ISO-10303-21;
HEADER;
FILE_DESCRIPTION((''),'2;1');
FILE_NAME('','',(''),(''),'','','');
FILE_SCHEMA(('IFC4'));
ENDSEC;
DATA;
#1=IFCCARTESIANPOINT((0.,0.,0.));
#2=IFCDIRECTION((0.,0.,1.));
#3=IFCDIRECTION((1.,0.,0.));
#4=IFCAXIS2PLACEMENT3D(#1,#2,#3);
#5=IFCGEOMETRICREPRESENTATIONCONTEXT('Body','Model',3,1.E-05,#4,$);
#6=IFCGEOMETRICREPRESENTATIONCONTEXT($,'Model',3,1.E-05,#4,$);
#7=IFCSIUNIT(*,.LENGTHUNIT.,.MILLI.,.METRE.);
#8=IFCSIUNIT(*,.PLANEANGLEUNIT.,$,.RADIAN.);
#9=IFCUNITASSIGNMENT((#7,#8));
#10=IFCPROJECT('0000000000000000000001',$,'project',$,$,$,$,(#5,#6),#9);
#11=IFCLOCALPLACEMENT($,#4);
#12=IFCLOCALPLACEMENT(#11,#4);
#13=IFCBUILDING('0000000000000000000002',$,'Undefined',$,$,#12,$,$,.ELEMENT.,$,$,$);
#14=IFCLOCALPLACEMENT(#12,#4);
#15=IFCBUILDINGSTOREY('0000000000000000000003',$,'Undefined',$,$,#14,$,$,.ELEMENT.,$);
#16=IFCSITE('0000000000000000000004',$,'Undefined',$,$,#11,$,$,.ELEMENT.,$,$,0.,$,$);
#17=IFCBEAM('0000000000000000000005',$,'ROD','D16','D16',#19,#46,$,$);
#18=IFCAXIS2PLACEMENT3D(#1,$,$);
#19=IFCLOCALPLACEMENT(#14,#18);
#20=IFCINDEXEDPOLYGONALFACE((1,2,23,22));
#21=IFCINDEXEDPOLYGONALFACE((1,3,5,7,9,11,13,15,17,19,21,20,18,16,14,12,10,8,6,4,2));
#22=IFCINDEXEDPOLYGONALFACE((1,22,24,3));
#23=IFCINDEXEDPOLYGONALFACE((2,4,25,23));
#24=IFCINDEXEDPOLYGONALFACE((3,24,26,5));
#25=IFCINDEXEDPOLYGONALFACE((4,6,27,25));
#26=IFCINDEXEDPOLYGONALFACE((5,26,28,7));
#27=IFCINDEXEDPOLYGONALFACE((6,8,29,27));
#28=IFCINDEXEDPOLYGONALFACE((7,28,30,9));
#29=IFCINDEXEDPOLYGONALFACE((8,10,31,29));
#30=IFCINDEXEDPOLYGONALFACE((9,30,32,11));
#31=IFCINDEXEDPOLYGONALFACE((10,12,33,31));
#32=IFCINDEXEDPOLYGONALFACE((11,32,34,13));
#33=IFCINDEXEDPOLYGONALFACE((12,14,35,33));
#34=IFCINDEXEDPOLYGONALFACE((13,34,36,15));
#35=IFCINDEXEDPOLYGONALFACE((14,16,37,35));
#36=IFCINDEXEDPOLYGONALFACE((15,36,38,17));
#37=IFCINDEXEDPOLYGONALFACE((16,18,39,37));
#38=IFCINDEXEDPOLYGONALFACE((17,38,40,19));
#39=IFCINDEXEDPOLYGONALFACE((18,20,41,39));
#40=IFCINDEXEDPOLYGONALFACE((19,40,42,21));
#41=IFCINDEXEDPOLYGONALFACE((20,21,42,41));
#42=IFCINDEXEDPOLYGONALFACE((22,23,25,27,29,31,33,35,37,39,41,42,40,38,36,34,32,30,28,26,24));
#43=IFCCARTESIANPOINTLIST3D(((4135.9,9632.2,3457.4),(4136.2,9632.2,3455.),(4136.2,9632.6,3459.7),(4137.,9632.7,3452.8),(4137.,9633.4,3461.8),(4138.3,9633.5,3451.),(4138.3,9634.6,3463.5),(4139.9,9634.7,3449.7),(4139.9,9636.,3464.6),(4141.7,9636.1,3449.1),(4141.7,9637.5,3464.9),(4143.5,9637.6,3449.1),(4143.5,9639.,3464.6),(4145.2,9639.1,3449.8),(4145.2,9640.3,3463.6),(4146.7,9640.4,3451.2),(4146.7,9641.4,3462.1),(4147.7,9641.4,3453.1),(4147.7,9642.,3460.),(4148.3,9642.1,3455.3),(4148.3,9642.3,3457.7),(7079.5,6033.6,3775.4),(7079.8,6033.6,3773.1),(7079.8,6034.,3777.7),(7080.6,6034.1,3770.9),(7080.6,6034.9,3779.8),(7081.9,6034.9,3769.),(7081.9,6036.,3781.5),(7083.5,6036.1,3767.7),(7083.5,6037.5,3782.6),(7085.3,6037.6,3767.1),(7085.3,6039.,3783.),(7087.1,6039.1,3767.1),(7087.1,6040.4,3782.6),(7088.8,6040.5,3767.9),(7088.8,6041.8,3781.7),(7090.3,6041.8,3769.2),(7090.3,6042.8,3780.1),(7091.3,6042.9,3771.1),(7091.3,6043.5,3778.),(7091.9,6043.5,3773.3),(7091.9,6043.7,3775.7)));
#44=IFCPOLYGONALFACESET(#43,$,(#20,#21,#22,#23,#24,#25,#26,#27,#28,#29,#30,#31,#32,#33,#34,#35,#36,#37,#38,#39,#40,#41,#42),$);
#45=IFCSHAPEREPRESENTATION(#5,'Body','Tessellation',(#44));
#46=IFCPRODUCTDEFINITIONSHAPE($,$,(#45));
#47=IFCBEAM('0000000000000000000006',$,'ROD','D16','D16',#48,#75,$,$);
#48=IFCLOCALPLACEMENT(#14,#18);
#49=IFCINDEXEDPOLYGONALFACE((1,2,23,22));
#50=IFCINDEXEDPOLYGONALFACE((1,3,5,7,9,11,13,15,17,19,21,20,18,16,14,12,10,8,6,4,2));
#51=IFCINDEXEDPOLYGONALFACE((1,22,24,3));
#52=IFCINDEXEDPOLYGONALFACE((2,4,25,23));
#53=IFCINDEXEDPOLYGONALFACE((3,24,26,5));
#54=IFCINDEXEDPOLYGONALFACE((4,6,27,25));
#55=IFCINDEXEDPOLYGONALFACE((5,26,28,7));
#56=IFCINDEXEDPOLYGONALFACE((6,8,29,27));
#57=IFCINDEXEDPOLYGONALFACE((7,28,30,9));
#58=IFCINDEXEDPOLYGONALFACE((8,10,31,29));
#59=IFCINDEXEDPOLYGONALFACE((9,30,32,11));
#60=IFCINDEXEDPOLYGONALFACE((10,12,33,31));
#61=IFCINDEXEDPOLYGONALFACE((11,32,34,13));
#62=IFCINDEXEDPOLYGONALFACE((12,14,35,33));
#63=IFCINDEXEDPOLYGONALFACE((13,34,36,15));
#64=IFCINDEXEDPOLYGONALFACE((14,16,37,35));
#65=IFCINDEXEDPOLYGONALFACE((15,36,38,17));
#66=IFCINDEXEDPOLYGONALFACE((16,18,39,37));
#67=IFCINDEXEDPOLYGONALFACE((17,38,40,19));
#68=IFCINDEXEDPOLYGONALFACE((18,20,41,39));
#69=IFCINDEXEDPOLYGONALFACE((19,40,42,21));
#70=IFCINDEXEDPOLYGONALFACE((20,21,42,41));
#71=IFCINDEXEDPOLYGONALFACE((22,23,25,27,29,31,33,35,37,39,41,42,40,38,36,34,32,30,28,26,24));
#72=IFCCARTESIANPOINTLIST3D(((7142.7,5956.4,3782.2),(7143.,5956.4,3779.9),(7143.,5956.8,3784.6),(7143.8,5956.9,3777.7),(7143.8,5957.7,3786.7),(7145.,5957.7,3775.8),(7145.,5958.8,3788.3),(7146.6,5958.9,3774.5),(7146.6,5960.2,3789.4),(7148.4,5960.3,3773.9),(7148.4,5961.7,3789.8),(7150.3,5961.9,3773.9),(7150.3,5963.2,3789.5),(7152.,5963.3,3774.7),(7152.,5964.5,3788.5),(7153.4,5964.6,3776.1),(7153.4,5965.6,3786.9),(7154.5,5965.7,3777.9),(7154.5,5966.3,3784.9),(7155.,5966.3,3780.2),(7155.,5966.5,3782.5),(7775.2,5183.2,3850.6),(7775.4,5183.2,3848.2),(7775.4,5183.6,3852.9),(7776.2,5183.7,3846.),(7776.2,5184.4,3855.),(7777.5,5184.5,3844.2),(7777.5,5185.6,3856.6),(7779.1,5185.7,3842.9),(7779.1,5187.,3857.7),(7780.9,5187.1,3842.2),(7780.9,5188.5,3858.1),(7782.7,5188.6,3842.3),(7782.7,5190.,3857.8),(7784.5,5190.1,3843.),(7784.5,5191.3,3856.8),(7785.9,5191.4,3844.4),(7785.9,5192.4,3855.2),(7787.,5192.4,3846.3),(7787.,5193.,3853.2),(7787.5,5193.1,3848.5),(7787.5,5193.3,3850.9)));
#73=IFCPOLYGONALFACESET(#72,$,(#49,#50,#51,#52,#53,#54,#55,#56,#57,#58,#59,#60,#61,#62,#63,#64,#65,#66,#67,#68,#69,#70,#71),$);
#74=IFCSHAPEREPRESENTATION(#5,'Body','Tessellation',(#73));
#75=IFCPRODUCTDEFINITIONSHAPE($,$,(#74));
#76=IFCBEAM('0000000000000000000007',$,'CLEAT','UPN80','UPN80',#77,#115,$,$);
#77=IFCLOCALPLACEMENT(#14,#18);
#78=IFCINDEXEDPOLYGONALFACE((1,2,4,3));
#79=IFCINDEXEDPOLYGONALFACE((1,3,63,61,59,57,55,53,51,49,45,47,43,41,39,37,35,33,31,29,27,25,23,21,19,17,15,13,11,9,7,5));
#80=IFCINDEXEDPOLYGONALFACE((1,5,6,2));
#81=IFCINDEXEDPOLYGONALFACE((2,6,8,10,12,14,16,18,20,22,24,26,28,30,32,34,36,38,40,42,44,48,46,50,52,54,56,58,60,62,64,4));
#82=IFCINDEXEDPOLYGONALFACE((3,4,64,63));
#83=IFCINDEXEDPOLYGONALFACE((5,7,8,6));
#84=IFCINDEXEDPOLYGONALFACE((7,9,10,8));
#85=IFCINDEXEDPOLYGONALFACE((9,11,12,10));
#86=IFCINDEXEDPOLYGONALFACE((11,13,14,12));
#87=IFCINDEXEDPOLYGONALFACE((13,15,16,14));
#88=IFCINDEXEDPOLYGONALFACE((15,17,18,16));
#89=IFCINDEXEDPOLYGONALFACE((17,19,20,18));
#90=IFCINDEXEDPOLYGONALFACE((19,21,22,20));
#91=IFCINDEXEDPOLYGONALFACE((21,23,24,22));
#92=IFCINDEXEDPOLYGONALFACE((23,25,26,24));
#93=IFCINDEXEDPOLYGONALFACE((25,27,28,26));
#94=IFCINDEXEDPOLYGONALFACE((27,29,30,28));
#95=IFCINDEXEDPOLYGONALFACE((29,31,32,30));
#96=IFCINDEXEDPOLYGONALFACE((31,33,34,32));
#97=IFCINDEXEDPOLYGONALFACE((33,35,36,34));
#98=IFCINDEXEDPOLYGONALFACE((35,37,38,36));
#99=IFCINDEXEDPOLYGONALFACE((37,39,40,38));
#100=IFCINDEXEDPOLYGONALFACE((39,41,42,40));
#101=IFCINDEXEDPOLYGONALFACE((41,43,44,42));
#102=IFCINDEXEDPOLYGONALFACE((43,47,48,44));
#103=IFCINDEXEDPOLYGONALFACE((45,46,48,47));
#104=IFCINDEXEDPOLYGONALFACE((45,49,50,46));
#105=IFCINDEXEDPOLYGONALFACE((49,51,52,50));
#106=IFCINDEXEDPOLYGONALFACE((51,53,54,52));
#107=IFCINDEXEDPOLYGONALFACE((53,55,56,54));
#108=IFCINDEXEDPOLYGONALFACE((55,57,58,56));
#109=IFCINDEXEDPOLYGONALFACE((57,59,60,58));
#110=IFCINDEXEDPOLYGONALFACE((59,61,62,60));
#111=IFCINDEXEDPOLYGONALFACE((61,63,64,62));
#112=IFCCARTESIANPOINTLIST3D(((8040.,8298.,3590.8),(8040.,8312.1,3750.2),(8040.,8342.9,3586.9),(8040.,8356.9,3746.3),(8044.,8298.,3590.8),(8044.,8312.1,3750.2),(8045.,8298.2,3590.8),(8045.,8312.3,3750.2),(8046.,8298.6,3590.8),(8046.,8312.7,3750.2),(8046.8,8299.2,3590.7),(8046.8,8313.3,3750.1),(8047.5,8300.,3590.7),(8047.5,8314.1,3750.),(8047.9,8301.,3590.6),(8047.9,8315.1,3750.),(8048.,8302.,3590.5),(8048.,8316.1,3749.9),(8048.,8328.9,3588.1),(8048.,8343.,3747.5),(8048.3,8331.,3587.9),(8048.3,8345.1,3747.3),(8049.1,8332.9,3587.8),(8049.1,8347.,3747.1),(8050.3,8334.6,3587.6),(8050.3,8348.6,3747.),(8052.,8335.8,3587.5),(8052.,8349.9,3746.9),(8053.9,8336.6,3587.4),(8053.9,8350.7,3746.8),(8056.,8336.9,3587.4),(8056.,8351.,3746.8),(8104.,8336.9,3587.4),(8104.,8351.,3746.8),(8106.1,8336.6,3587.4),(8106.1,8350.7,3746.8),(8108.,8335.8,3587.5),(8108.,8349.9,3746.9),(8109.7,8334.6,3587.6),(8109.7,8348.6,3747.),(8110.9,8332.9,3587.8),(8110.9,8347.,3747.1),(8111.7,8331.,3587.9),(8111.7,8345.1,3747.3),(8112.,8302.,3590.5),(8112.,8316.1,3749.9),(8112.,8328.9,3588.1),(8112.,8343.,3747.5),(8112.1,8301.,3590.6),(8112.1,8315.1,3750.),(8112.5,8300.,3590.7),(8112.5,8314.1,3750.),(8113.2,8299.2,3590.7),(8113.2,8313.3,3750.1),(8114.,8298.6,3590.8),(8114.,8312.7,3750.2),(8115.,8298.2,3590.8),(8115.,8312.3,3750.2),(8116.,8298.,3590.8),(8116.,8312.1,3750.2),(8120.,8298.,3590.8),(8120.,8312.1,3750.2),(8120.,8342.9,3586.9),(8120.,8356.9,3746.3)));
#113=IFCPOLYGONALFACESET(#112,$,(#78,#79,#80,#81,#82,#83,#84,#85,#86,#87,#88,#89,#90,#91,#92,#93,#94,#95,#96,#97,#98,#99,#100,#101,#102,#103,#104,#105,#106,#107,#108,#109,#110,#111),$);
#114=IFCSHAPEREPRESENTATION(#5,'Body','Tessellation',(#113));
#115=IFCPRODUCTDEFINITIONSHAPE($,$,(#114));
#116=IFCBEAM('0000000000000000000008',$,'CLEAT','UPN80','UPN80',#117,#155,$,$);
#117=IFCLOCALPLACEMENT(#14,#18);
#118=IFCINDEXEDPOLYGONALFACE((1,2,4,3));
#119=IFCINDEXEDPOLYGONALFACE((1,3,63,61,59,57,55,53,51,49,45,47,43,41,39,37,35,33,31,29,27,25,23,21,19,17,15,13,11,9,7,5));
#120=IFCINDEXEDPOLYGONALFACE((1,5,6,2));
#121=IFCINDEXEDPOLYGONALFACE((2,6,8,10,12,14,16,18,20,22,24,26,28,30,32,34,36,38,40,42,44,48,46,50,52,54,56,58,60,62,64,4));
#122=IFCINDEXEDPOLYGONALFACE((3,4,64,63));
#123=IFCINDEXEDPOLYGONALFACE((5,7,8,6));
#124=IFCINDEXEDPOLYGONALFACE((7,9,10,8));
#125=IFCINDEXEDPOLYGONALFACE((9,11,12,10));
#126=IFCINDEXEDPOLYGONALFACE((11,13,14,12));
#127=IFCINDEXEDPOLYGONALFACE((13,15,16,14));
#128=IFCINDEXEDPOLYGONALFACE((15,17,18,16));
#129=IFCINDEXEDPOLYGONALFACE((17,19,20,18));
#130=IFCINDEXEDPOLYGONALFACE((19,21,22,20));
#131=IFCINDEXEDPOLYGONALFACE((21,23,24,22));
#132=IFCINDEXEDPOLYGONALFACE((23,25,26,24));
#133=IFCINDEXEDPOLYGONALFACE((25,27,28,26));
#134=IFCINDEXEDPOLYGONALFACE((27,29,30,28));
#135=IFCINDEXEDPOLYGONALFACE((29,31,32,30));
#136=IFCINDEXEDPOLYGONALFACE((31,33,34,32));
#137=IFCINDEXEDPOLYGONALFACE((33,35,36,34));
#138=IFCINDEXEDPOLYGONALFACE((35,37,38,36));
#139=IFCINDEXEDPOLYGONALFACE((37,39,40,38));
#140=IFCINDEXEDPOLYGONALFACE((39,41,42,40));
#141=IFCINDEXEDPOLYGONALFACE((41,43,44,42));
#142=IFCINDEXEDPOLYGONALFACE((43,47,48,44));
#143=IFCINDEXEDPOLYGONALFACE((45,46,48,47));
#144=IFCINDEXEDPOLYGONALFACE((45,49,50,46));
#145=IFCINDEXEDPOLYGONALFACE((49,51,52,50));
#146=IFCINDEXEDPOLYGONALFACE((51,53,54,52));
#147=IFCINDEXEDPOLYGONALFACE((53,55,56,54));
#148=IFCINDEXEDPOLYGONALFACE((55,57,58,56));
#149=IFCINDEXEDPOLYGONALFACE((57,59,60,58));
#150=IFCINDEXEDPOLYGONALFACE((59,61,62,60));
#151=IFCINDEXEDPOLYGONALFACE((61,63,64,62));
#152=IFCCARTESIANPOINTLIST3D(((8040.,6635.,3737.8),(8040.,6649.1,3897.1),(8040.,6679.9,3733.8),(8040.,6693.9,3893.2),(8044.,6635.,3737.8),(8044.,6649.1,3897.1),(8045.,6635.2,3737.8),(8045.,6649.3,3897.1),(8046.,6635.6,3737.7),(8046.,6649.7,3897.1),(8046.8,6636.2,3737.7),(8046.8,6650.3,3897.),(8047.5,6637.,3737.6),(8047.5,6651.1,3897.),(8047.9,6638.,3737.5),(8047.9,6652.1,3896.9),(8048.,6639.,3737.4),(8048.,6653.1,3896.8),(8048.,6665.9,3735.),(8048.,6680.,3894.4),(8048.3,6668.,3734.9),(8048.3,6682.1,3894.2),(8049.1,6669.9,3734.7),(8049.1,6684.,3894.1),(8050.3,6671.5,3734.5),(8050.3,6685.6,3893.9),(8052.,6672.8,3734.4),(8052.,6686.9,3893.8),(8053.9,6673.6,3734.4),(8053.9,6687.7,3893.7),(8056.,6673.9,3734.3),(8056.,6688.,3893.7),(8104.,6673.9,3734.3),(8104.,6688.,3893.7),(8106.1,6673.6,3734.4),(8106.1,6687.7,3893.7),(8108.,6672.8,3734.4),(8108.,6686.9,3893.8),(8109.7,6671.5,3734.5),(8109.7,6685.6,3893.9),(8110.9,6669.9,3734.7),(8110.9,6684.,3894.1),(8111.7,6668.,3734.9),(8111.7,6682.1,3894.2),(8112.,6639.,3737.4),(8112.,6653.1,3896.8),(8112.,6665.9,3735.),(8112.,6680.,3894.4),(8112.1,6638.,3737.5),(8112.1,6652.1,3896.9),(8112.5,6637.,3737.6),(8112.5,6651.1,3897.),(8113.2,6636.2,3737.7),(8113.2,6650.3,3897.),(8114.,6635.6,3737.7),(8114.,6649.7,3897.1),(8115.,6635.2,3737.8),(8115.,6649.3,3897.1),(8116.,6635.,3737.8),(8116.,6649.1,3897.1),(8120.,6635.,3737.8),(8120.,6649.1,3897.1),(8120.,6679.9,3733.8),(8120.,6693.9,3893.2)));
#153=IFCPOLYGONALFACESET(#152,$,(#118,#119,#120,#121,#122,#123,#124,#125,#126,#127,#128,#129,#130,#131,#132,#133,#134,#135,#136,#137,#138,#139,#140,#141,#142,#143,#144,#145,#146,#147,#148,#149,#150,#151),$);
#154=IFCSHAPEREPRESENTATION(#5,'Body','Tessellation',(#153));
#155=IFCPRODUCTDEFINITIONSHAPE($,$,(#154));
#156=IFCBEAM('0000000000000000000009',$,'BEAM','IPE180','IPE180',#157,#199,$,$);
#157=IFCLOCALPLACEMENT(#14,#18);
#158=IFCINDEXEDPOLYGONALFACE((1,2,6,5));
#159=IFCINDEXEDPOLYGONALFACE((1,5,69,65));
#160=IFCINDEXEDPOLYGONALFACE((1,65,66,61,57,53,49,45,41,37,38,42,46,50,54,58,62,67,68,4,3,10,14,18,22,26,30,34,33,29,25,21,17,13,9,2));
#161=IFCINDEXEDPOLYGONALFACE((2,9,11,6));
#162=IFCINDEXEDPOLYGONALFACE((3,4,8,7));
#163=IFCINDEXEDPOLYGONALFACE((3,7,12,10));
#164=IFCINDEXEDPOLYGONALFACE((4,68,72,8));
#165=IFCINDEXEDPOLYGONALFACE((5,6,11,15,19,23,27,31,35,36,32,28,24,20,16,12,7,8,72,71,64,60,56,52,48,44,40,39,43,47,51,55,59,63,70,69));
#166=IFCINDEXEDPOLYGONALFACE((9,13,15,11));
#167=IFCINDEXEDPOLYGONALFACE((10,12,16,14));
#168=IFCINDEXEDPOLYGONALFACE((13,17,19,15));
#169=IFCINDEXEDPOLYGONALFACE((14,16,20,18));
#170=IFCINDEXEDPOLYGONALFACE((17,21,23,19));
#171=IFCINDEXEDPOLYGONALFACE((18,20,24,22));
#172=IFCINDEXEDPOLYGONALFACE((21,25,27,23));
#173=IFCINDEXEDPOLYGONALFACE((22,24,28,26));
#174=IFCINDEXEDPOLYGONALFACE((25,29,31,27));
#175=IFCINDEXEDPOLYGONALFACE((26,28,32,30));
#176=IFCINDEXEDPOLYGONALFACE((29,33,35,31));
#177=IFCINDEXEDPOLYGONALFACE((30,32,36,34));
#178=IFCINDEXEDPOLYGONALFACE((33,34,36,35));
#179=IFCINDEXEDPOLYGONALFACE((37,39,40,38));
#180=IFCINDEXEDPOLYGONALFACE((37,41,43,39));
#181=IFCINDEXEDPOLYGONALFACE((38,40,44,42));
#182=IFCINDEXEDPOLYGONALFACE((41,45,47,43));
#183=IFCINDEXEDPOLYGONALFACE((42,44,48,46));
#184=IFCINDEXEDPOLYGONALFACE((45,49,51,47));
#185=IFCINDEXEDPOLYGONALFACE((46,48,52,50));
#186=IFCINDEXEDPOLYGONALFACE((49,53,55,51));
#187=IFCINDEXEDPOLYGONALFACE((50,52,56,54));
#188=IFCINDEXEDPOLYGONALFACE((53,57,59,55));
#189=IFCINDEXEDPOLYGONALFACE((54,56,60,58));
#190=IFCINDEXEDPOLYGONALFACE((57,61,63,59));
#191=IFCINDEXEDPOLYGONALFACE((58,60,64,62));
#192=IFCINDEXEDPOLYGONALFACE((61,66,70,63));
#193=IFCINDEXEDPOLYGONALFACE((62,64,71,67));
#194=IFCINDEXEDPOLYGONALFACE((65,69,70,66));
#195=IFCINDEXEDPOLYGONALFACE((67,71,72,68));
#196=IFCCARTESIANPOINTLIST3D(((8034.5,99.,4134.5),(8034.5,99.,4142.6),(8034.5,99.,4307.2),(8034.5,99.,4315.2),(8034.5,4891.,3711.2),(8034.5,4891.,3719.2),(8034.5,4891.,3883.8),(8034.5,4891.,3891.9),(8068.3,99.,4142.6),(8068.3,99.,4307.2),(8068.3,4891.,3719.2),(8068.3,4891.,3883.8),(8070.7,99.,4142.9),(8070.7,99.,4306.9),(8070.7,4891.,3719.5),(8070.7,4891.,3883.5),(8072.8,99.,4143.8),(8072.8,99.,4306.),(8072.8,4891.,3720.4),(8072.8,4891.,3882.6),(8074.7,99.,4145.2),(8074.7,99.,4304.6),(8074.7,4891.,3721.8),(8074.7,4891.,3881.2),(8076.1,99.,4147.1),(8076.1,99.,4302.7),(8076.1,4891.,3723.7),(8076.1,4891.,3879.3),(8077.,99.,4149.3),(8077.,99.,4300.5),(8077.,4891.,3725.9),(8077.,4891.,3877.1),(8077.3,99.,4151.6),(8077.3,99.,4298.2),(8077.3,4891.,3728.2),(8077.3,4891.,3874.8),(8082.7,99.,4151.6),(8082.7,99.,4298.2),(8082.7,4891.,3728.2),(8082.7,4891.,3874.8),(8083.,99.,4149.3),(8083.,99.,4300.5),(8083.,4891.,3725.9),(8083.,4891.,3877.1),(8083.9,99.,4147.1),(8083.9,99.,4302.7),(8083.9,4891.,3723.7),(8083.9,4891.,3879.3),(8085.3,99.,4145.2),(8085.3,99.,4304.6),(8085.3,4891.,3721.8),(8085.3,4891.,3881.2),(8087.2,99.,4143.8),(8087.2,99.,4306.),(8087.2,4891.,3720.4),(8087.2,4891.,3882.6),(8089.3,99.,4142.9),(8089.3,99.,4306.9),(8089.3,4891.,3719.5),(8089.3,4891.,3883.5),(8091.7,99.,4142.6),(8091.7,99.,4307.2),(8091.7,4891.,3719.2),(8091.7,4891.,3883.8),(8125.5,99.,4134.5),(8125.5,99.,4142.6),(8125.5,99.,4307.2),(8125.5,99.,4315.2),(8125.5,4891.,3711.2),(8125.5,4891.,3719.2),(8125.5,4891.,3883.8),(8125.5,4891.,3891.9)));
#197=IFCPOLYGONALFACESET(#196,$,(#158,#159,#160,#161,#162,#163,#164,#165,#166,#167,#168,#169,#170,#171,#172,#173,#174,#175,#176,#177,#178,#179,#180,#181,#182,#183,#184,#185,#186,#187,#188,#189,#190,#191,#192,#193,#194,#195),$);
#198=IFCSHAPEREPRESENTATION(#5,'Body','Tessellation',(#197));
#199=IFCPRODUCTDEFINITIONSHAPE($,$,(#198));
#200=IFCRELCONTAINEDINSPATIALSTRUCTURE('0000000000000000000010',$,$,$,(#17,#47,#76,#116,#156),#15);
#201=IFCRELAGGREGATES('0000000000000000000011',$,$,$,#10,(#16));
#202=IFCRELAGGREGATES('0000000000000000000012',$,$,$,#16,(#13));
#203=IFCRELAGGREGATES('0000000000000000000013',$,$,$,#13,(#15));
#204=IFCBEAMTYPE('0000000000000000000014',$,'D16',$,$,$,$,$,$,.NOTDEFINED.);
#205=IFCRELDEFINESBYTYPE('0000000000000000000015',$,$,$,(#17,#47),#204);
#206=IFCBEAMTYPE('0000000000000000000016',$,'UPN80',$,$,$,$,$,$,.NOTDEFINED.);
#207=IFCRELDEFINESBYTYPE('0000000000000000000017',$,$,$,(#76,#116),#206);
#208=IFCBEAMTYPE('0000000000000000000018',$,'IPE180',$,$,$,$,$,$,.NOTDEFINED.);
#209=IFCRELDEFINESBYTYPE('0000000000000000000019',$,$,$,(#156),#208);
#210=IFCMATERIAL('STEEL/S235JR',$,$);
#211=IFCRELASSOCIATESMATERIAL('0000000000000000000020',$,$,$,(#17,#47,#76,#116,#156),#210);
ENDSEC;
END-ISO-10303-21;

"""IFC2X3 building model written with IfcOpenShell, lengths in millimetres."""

from ifc_helpers import new_model, si_unit, frame, origin_with_axes, origin_2d_with_axis, place, context, project, spatial, circle, i_section, u_section, extrude, clip, halfspace, material, type_object, element, save


model = new_model("IFC2X3")

# Units and contexts
model_context_1 = context("Model", 3, precision=1e-05, world=origin_with_axes(), identifier="Body")
model_context_2 = context("Model", 3, precision=1e-05, world=origin_with_axes())
ifc_project = project(units=[si_unit("LENGTHUNIT", "METRE", prefix="MILLI"), si_unit("PLANEANGLEUNIT", "RADIAN")], contexts=[model_context_1, model_context_2])

# Site, building, storey
site_placement = place(None, origin_with_axes())
site = spatial("IfcSite", under=ifc_project, at=site_placement, Name="Undefined", CompositionType="ELEMENT", RefElevation=0.0)
building_placement = place(site_placement, origin_with_axes())
building = spatial("IfcBuilding", under=site, at=building_placement, Name="Undefined", CompositionType="ELEMENT")
storey_placement = place(building_placement, origin_with_axes())
storey = spatial("IfcBuildingStorey", under=building, at=storey_placement, Name="Undefined", CompositionType="ELEMENT")

# Shared definitions
ifc_material = material(Name="STEEL/S235JR")

# Beams
beam_type_1 = type_object("IfcBeamType", Name="D16", PredefinedType="NOTDEFINED")
beam_1_placement = place(storey_placement, frame((7085.7, 6038.6, 3775.0), z_axis=(0.0, -0.088027, -0.996118), x_axis=(-0.631673, 0.772225, -0.068242)))
element("IfcBeam", 1, at=beam_1_placement, inside=storey, type_object=beam_type_1, material=ifc_material, Name="ROD", Description="D16", ObjectType="D16", context=model_context_1, shape_type="SweptSolid", body=[
    extrude(circle(Radius=8.0, at=origin_2d_with_axis()), frame((4660.0, 0.0, 0.0), z_axis=(-1.0, 0.0, 0.0), x_axis=(0.0, -1.0, 0.0)), (0.0, 0.0, 1.0), 4660.0),
])
beam_2_placement = place(storey_placement, frame((7781.4, 5188.2, 3850.1), z_axis=(0.0, -0.088027, -0.996118), x_axis=(-0.631673, 0.772225, -0.068242)))
element("IfcBeam", 2, at=beam_2_placement, inside=storey, type_object=beam_type_1, material=ifc_material, Name="ROD", Description="D16", ObjectType="D16", context=model_context_1, shape_type="SweptSolid", body=[
    extrude(circle(Radius=8.0, at=origin_2d_with_axis()), frame((1001.3, 0.0, 0.0), z_axis=(-1.0, 0.0, 0.0), x_axis=(0.0, -1.0, 0.0)), (0.0, 0.0, 1.0), 1001.3),
])
beam_type_2 = type_object("IfcBeamType", Name="UPN80", PredefinedType="NOTDEFINED")
for number, where, z_axis, x_axis, name in (
    (3, (8080.0, 8320.4, 3588.9), (-1.0, 0.0, 0.0), (0.0, 0.08801, 0.99612), "CLEAT"),
    (4, (8080.0, 6657.4, 3735.8), (-1.0, 0.0, 0.0), (0.0, 0.08801, 0.99612), "CLEAT"),
):
    element("IfcBeam", number, at=place(storey_placement, frame(where, z_axis=z_axis, x_axis=x_axis)), inside=storey, type_object=beam_type_2, material=ifc_material, Name=name, Description="UPN80", ObjectType="UPN80", context=model_context_1, shape_type="SweptSolid", body=[
        extrude(u_section(Depth=80.0, FlangeWidth=45.0, WebThickness=6.0, FlangeThickness=8.0, FilletRadius=8.0, EdgeRadius=4.0, at=origin_2d_with_axis()), frame((160.0, 0.0, 0.0), z_axis=(-1.0, 0.0, 0.0), x_axis=(0.0, -1.0, 0.0)), (0.0, 0.0, 1.0), 160.0),
    ])
beam_type_3 = type_object("IfcBeamType", Name="IPE180", PredefinedType="NOTDEFINED")
beam_3_placement = place(storey_placement, frame((8080.0, 4910.6, 3799.8), z_axis=(0.0, 0.08801, 0.99612), x_axis=(0.0, -0.99612, 0.08801)))
element("IfcBeam", 5, at=beam_3_placement, inside=storey, type_object=beam_type_3, material=ifc_material, Name="BEAM", Description="IPE180", ObjectType="IPE180", context=model_context_1, shape_type="Clipping", body=[
    clip(clip(extrude(i_section(OverallWidth=91.0, OverallDepth=180.0, WebThickness=5.3, FlangeThickness=8.0, FilletRadius=9.0, at=origin_2d_with_axis()), frame((4846.4, 0.0, 0.0), z_axis=(-1.0, 0.0, 0.0), x_axis=(0.0, -1.0, 0.0)), (0.0, 0.0, 1.0), 4842.8), halfspace(frame((11.7, 0.0, -90.0), z_axis=(0.99612, 0.0, -0.08801), x_axis=(0.0, -1.0, 0.0)), True)), halfspace(frame((4839.2, 0.0, 100.8), z_axis=(0.99612, 0.0, -0.08801), x_axis=(0.0, 1.0, 0.0)), False)),
])

save(model, "model.ifc")
